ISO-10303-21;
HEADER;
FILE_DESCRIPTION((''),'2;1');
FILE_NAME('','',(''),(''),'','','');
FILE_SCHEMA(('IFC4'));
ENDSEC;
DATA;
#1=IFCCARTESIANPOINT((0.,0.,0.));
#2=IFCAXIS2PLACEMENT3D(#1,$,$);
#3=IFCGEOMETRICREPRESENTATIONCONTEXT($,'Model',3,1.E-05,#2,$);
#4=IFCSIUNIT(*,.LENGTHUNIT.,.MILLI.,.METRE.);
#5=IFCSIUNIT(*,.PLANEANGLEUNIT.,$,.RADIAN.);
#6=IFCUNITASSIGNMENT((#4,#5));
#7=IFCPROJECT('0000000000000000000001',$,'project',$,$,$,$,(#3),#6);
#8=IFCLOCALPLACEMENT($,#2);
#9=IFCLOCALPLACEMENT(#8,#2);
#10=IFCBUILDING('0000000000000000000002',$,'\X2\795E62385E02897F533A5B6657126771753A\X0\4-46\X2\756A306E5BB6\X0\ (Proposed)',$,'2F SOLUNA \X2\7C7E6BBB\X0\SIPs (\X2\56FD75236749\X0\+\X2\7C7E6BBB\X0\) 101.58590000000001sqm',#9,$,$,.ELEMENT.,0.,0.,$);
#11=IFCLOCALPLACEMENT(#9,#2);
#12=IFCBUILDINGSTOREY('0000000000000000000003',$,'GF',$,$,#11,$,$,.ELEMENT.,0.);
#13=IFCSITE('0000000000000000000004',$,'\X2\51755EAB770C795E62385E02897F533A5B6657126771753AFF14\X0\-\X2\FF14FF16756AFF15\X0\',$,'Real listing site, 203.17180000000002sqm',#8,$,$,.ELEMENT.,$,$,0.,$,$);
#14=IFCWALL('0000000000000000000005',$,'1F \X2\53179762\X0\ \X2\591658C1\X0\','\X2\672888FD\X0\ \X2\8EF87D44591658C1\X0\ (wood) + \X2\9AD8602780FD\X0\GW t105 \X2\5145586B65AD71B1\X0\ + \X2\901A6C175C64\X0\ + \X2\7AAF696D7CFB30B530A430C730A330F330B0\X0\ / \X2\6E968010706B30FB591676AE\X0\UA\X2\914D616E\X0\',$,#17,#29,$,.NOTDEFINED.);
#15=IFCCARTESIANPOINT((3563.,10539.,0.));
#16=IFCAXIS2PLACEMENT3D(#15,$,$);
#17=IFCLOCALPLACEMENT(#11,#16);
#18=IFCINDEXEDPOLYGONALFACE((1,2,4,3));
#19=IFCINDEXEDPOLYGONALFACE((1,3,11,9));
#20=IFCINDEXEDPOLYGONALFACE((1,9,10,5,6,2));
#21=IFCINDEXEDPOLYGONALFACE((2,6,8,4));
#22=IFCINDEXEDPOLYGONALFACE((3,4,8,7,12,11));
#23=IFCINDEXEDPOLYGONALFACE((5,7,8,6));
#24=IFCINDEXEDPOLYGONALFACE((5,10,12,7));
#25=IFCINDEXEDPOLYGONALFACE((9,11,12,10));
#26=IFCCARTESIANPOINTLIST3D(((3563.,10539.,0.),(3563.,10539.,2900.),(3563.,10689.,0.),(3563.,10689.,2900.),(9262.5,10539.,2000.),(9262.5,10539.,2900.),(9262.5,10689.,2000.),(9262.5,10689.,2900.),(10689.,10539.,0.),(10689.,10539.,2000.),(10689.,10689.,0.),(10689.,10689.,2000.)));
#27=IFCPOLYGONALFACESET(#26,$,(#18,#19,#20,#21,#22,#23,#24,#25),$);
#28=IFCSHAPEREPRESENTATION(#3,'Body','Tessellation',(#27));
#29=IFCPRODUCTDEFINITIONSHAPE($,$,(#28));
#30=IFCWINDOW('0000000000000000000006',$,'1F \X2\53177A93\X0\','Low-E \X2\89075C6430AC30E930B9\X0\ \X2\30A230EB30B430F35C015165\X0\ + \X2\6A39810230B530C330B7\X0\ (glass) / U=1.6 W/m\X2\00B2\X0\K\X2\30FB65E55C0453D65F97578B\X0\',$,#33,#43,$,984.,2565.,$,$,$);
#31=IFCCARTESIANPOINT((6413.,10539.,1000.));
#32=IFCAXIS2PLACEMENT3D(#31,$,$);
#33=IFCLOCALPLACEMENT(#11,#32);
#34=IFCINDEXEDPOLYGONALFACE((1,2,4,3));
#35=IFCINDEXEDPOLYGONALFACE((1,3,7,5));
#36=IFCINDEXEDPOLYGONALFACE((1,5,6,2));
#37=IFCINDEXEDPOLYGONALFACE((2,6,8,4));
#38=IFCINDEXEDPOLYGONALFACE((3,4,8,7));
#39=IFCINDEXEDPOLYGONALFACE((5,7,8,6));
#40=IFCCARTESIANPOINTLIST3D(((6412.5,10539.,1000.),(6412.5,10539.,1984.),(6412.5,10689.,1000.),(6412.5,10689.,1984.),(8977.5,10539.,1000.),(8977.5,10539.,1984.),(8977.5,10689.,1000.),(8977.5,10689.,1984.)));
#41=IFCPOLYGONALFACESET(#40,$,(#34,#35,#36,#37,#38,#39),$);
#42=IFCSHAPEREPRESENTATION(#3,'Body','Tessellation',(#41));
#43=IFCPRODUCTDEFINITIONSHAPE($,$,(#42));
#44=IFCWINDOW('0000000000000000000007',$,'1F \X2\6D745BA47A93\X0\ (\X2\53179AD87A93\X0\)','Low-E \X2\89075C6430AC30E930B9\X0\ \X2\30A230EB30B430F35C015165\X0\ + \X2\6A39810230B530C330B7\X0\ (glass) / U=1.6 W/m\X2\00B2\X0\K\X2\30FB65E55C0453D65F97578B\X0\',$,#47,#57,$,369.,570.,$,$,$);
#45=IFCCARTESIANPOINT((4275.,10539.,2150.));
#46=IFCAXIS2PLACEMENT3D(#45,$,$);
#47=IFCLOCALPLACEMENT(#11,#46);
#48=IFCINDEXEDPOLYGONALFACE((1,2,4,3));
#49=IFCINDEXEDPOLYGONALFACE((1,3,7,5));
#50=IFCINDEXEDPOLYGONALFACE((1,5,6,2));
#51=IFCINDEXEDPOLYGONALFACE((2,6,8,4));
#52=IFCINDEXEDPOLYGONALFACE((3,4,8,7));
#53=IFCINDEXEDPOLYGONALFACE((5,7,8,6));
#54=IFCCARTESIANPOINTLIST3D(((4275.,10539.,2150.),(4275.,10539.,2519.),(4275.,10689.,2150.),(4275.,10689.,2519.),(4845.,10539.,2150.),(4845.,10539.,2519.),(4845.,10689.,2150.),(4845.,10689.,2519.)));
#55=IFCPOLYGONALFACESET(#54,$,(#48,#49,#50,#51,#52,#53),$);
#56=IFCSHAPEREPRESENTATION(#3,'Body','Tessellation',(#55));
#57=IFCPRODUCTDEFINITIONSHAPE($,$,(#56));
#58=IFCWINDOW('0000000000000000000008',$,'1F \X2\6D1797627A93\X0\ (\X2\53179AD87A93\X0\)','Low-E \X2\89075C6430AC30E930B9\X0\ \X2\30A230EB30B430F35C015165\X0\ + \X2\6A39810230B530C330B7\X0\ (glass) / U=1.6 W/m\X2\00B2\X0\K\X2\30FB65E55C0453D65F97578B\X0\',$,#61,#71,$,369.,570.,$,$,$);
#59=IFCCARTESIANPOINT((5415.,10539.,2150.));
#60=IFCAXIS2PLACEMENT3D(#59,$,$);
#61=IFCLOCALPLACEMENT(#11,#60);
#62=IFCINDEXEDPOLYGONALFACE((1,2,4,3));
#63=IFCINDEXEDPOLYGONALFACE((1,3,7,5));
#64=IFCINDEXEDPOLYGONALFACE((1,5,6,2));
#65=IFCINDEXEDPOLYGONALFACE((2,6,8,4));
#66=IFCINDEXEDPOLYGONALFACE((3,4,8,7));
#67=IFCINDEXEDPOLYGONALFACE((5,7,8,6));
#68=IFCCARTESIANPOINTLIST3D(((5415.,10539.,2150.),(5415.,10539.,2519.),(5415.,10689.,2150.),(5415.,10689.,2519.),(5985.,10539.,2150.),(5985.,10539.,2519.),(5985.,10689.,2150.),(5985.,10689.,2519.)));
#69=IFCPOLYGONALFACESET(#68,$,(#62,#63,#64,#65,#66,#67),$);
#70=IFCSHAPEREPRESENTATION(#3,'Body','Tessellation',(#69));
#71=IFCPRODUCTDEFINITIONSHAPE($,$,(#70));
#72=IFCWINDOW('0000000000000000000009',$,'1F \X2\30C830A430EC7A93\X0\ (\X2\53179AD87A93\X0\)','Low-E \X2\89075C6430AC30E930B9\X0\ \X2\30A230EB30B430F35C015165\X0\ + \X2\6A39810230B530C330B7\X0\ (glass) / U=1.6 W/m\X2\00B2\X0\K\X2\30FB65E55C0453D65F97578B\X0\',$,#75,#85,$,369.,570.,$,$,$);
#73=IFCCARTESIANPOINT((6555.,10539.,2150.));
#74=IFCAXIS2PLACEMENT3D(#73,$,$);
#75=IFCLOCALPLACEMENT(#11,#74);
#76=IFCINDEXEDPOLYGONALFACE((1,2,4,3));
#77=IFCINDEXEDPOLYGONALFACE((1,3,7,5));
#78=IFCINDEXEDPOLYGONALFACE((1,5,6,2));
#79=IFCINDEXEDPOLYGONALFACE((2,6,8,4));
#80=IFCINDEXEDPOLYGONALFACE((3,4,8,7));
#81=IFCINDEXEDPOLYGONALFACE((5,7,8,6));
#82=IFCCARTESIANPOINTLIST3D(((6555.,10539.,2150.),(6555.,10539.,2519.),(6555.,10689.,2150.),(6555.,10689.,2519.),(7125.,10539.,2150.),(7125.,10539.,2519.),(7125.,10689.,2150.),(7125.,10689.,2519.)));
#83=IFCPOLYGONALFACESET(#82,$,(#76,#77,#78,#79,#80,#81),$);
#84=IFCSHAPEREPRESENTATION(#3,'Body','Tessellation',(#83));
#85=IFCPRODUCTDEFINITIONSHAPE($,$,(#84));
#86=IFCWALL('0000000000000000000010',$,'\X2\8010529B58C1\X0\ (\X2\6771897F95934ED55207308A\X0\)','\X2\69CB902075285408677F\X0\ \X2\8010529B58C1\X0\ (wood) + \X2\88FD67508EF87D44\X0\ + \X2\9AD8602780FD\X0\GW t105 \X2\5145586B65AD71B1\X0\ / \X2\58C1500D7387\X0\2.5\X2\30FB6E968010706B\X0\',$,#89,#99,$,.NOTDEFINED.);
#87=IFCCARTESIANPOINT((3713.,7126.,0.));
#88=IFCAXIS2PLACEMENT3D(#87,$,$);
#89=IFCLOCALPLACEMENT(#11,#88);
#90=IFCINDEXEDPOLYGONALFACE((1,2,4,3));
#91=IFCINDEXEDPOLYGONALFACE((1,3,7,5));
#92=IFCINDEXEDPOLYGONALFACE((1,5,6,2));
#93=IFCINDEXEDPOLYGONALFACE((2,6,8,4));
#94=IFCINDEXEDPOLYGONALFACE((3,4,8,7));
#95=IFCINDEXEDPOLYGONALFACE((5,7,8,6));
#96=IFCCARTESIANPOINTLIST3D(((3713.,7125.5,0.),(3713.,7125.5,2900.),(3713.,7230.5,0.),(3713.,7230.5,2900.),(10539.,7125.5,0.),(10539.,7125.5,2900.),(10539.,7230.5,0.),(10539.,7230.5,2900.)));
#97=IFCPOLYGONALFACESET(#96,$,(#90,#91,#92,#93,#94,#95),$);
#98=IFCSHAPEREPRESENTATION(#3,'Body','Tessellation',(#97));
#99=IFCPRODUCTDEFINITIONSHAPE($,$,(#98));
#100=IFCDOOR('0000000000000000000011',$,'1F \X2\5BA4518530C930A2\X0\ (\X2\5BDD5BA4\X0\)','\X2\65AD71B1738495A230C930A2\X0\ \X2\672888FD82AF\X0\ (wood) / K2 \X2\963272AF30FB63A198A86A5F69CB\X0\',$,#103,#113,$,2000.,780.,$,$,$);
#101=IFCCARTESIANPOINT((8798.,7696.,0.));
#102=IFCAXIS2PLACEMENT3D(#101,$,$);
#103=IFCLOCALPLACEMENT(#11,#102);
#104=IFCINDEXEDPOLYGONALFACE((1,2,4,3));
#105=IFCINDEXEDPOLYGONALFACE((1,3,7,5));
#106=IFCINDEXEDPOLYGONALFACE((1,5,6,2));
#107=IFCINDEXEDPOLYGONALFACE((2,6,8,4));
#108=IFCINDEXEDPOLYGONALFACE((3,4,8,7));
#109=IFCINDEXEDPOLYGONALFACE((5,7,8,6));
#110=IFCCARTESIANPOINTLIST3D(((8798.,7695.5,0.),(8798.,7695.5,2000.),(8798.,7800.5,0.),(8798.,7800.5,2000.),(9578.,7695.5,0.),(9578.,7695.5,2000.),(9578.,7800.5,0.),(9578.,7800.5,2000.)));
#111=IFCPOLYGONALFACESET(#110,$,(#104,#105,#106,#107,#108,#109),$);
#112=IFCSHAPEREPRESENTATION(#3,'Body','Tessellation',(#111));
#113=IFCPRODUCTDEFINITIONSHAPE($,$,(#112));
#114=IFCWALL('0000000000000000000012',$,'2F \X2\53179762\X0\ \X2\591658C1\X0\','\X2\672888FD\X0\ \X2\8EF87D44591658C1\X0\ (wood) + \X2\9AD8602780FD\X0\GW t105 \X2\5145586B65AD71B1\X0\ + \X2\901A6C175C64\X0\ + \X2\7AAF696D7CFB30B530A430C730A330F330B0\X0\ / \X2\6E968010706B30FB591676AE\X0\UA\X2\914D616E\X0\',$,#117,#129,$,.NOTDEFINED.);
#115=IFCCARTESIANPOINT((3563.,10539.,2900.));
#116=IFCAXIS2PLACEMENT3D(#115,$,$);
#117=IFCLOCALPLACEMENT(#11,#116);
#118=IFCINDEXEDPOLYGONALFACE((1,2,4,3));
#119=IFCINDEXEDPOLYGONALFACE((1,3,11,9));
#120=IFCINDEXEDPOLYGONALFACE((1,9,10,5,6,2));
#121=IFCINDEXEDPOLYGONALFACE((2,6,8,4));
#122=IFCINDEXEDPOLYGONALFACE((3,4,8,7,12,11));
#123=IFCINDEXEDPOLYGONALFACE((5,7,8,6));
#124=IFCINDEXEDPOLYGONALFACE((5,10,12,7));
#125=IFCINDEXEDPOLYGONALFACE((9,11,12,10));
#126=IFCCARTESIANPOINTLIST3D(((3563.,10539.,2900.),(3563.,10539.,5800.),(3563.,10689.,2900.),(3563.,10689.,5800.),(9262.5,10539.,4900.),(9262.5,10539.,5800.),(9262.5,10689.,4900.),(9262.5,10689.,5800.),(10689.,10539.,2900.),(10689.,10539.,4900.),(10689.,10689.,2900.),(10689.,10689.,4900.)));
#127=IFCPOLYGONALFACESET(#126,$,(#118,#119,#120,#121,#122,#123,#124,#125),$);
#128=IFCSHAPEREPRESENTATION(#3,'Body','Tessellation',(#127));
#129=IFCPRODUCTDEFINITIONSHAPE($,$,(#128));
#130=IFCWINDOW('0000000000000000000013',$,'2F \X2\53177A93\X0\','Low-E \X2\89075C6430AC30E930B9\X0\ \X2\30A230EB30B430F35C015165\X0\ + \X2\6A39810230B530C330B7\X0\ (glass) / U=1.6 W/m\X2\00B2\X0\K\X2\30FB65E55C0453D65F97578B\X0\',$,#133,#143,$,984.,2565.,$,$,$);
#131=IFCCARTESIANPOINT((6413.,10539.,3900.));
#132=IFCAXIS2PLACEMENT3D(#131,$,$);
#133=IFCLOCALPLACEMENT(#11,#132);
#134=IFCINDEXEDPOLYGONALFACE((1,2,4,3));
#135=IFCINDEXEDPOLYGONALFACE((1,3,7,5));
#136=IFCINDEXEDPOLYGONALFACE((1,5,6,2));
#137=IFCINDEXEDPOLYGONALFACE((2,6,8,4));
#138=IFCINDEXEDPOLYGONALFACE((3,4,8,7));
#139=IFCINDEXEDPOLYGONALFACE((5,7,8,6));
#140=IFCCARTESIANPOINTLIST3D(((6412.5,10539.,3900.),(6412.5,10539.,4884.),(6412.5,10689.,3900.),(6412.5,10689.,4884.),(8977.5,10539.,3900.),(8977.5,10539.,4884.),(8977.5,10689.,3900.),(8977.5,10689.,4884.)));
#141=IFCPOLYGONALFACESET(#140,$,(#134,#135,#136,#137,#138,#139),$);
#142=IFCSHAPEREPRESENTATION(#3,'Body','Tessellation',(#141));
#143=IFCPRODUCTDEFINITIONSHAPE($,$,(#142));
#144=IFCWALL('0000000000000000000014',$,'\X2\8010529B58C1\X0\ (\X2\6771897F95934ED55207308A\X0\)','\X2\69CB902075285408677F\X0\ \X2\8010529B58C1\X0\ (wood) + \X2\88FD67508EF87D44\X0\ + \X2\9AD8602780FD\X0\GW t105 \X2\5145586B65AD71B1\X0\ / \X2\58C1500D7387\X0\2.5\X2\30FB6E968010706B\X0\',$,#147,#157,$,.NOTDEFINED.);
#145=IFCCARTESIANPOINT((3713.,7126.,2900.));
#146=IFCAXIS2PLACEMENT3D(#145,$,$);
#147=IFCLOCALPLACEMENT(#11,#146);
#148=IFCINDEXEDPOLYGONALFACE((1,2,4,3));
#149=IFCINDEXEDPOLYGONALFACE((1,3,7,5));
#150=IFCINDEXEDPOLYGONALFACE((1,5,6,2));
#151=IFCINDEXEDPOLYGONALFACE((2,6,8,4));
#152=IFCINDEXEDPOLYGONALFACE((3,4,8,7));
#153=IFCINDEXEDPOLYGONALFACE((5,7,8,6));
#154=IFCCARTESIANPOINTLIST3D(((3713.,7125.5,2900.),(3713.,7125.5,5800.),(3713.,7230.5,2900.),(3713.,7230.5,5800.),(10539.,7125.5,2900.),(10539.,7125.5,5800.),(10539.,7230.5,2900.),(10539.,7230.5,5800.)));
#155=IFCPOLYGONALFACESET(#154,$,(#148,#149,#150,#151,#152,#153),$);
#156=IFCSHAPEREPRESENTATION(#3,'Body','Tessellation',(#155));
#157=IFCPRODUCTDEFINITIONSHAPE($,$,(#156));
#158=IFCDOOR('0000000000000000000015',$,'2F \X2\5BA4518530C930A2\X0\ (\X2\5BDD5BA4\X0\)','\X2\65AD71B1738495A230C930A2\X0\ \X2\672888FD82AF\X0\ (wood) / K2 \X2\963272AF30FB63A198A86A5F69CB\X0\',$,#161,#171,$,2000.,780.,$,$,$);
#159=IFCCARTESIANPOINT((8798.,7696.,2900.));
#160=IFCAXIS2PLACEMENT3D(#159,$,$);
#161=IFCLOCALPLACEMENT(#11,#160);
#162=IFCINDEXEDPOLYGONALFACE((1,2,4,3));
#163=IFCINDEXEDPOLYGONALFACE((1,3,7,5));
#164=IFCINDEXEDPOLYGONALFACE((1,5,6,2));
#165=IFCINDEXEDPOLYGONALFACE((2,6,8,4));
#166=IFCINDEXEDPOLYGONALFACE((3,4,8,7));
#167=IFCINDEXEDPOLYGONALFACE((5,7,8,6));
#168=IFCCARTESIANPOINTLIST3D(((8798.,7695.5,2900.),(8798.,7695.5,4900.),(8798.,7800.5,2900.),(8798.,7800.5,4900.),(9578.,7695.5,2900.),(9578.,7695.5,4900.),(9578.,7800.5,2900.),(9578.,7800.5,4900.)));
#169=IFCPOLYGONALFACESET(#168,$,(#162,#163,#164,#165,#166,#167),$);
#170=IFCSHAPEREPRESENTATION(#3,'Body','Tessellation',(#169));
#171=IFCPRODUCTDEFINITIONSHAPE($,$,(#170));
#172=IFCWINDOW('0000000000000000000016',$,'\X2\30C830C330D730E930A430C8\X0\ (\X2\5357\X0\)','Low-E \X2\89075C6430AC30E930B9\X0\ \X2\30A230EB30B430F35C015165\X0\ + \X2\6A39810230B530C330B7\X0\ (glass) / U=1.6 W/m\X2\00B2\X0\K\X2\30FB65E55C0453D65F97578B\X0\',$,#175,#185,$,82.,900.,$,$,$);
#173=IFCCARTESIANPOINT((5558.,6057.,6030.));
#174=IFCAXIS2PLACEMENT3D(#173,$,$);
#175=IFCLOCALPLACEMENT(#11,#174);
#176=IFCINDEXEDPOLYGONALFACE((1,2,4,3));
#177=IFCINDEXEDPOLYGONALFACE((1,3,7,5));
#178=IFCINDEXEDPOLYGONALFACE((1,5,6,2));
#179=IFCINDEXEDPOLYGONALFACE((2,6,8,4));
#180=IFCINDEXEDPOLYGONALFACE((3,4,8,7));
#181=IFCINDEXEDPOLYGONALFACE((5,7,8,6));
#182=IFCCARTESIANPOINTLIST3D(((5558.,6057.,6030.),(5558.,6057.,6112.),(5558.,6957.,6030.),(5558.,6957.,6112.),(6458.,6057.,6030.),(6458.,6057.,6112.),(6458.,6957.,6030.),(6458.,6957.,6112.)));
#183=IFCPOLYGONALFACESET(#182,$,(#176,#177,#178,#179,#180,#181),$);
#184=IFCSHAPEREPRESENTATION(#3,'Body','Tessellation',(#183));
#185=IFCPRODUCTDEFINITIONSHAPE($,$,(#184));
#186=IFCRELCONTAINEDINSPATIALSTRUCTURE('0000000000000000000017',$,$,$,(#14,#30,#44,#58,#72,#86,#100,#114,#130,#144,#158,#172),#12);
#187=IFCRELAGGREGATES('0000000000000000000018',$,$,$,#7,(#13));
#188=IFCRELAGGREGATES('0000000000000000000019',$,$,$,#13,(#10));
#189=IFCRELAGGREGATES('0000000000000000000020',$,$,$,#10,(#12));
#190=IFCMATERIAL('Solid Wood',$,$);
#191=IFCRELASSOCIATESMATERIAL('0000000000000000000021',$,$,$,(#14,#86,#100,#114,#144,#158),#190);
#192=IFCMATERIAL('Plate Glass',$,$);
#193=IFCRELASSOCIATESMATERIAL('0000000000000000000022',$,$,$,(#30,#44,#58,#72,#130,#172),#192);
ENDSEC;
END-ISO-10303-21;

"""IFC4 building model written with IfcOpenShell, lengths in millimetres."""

from ifc_helpers import new_model, si_unit, frame, frame_2d, origin, place, context, project, spatial, rectangle, extrude, material, element, fill, save


model = new_model("IFC4")

# Units and contexts
model_context = context("Model", 3, precision=1e-05, world=origin())
ifc_project = project(units=[si_unit("LENGTHUNIT", "METRE", prefix="MILLI"), si_unit("PLANEANGLEUNIT", "RADIAN")], contexts=[model_context])

# Site, building, storey
site_placement = place(None, origin())
site = spatial("IfcSite", under=ifc_project, at=site_placement, Name="兵庫県神戸市西区学園東町４-４６番５", ObjectType="Real listing site, 203.17180000000002sqm", CompositionType="ELEMENT", RefElevation=0.0)
building_placement = place(site_placement, origin())
building = spatial("IfcBuilding", under=site, at=building_placement, Name="神戸市西区学園東町4-46番の家 (Proposed)", ObjectType="2F SOLUNA 籾殻SIPs (国産杉+籾殻) 101.58590000000001sqm", CompositionType="ELEMENT", ElevationOfRefHeight=0.0, ElevationOfTerrain=0.0)
storey_placement = place(building_placement, origin())
storey = spatial("IfcBuildingStorey", under=building, at=storey_placement, Name="GF", CompositionType="ELEMENT", Elevation=0.0)

# Wall, openings, windows
ifc_material_1 = material(Name="Solid Wood")
wall_1_placement = place(storey_placement, frame((3563.0, 10539.0, 0.0)))
wall_1 = element("IfcWall", 1, at=wall_1_placement, inside=storey, material=ifc_material_1, Name="1F 北面 外壁", Description="木製 軸組外壁 (wood) + 高性能GW t105 充填断熱 + 通気層 + 窯業系サイディング / 準耐火・外皮UA配慮", PredefinedType="NOTDEFINED", context=model_context, shape_type="SweptSolid", body=[
    extrude(rectangle(XDim=7126.0, YDim=150.0, at=frame_2d((3563.0, 75.0))), frame((3563.0, 10539.0, 0.0)), (0.0, 0.0, 1.0), 2900.0),
])
opening_1_placement = place(storey_placement, frame((6413.0, 10539.0, 1000.0)))
opening_1 = element("IfcOpeningElement", 2, at=opening_1_placement, cuts=wall_1, PredefinedType="NOTDEFINED", context=model_context, shape_type="SweptSolid", body=[
    extrude(rectangle(XDim=2565.0, YDim=150.0, at=frame_2d((1282.0, 75.0))), frame((6413.0, 10539.0, 1000.0)), (0.0, 0.0, 1.0), 984.0),
])
opening_2_placement = place(storey_placement, frame((4275.0, 10539.0, 2150.0)))
opening_2 = element("IfcOpeningElement", 3, at=opening_2_placement, cuts=wall_1, PredefinedType="NOTDEFINED", context=model_context, shape_type="SweptSolid", body=[
    extrude(rectangle(XDim=570.0, YDim=150.0, at=frame_2d((285.0, 75.0))), frame((4275.0, 10539.0, 2150.0)), (0.0, 0.0, 1.0), 369.0),
])
opening_3_placement = place(storey_placement, frame((5415.0, 10539.0, 2150.0)))
opening_3 = element("IfcOpeningElement", 4, at=opening_3_placement, cuts=wall_1, PredefinedType="NOTDEFINED", context=model_context, shape_type="SweptSolid", body=[
    extrude(rectangle(XDim=570.0, YDim=150.0, at=frame_2d((285.0, 75.0))), frame((5415.0, 10539.0, 2150.0)), (0.0, 0.0, 1.0), 369.0),
])
opening_4_placement = place(storey_placement, frame((6555.0, 10539.0, 2150.0)))
opening_4 = element("IfcOpeningElement", 5, at=opening_4_placement, cuts=wall_1, PredefinedType="NOTDEFINED", context=model_context, shape_type="SweptSolid", body=[
    extrude(rectangle(XDim=570.0, YDim=150.0, at=frame_2d((285.0, 75.0))), frame((6555.0, 10539.0, 2150.0)), (0.0, 0.0, 1.0), 369.0),
])
ifc_material_2 = material(Name="Plate Glass")
window_1_placement = place(storey_placement, frame((6413.0, 10539.0, 1000.0)))
window_1 = element("IfcWindow", 6, at=window_1_placement, inside=storey, material=ifc_material_2, Name="1F 北窓", Description="Low-E 複層ガラス アルゴン封入 + 樹脂サッシ (glass) / U=1.6 W/m²K・日射取得型", OverallHeight=984.0, OverallWidth=2565.0, context=model_context, shape_type="SweptSolid", body=[
    extrude(rectangle(XDim=2565.0, YDim=150.0, at=frame_2d((1282.0, 75.0))), frame((6413.0, 10539.0, 1000.0)), (0.0, 0.0, 1.0), 984.0),
])
fill(opening_1, window_1)
window_2_placement = place(storey_placement, frame((4275.0, 10539.0, 2150.0)))
window_2 = element("IfcWindow", 7, at=window_2_placement, inside=storey, material=ifc_material_2, Name="1F 浴室窓 (北高窓)", Description="Low-E 複層ガラス アルゴン封入 + 樹脂サッシ (glass) / U=1.6 W/m²K・日射取得型", OverallHeight=369.0, OverallWidth=570.0, context=model_context, shape_type="SweptSolid", body=[
    extrude(rectangle(XDim=570.0, YDim=150.0, at=frame_2d((285.0, 75.0))), frame((4275.0, 10539.0, 2150.0)), (0.0, 0.0, 1.0), 369.0),
])
fill(opening_2, window_2)
window_3_placement = place(storey_placement, frame((5415.0, 10539.0, 2150.0)))
window_3 = element("IfcWindow", 8, at=window_3_placement, inside=storey, material=ifc_material_2, Name="1F 洗面窓 (北高窓)", Description="Low-E 複層ガラス アルゴン封入 + 樹脂サッシ (glass) / U=1.6 W/m²K・日射取得型", OverallHeight=369.0, OverallWidth=570.0, context=model_context, shape_type="SweptSolid", body=[
    extrude(rectangle(XDim=570.0, YDim=150.0, at=frame_2d((285.0, 75.0))), frame((5415.0, 10539.0, 2150.0)), (0.0, 0.0, 1.0), 369.0),
])
fill(opening_3, window_3)
window_4_placement = place(storey_placement, frame((6555.0, 10539.0, 2150.0)))
window_4 = element("IfcWindow", 9, at=window_4_placement, inside=storey, material=ifc_material_2, Name="1F トイレ窓 (北高窓)", Description="Low-E 複層ガラス アルゴン封入 + 樹脂サッシ (glass) / U=1.6 W/m²K・日射取得型", OverallHeight=369.0, OverallWidth=570.0, context=model_context, shape_type="SweptSolid", body=[
    extrude(rectangle(XDim=570.0, YDim=150.0, at=frame_2d((285.0, 75.0))), frame((6555.0, 10539.0, 2150.0)), (0.0, 0.0, 1.0), 369.0),
])
fill(opening_4, window_4)

# Wall
wall_2_placement = place(storey_placement, frame((3713.0, 7126.0, 0.0)))
element("IfcWall", 10, at=wall_2_placement, inside=storey, material=ifc_material_1, Name="耐力壁 (東西間仕切り)", Description="構造用合板 耐力壁 (wood) + 製材軸組 + 高性能GW t105 充填断熱 / 壁倍率2.5・準耐火", PredefinedType="NOTDEFINED", context=model_context, shape_type="SweptSolid", body=[
    extrude(rectangle(XDim=6826.0, YDim=105.0, at=frame_2d((3413.0, 52.0))), frame((3713.0, 7126.0, 0.0)), (0.0, 0.0, 1.0), 2900.0),
])

# Door
door_1_placement = place(storey_placement, frame((8798.0, 7696.0, 0.0)))
element("IfcDoor", 11, at=door_1_placement, inside=storey, material=ifc_material_1, Name="1F 室内ドア (寝室)", Description="断熱玄関ドア 木製芯 (wood) / K2 防犯・採風機構", OverallHeight=2000.0, OverallWidth=780.0, context=model_context, shape_type="SweptSolid", body=[
    extrude(rectangle(XDim=780.0, YDim=105.0, at=frame_2d((390.0, 52.0))), frame((8798.0, 7696.0, 0.0)), (0.0, 0.0, 1.0), 2000.0),
])

# Wall, opening, window
wall_3_placement = place(storey_placement, frame((3563.0, 10539.0, 2900.0)))
wall_3 = element("IfcWall", 12, at=wall_3_placement, inside=storey, material=ifc_material_1, Name="2F 北面 外壁", Description="木製 軸組外壁 (wood) + 高性能GW t105 充填断熱 + 通気層 + 窯業系サイディング / 準耐火・外皮UA配慮", PredefinedType="NOTDEFINED", context=model_context, shape_type="SweptSolid", body=[
    extrude(rectangle(XDim=7126.0, YDim=150.0, at=frame_2d((3563.0, 75.0))), frame((3563.0, 10539.0, 2900.0)), (0.0, 0.0, 1.0), 2900.0),
])
opening_5_placement = place(storey_placement, frame((6413.0, 10539.0, 3900.0)))
opening_5 = element("IfcOpeningElement", 13, at=opening_5_placement, cuts=wall_3, PredefinedType="NOTDEFINED", context=model_context, shape_type="SweptSolid", body=[
    extrude(rectangle(XDim=2565.0, YDim=150.0, at=frame_2d((1282.0, 75.0))), frame((6413.0, 10539.0, 3900.0)), (0.0, 0.0, 1.0), 984.0),
])
window_5_placement = place(storey_placement, frame((6413.0, 10539.0, 3900.0)))
window_5 = element("IfcWindow", 14, at=window_5_placement, inside=storey, material=ifc_material_2, Name="2F 北窓", Description="Low-E 複層ガラス アルゴン封入 + 樹脂サッシ (glass) / U=1.6 W/m²K・日射取得型", OverallHeight=984.0, OverallWidth=2565.0, context=model_context, shape_type="SweptSolid", body=[
    extrude(rectangle(XDim=2565.0, YDim=150.0, at=frame_2d((1282.0, 75.0))), frame((6413.0, 10539.0, 3900.0)), (0.0, 0.0, 1.0), 984.0),
])
fill(opening_5, window_5)

# Wall
wall_4_placement = place(storey_placement, frame((3713.0, 7126.0, 2900.0)))
element("IfcWall", 15, at=wall_4_placement, inside=storey, material=ifc_material_1, Name="耐力壁 (東西間仕切り)", Description="構造用合板 耐力壁 (wood) + 製材軸組 + 高性能GW t105 充填断熱 / 壁倍率2.5・準耐火", PredefinedType="NOTDEFINED", context=model_context, shape_type="SweptSolid", body=[
    extrude(rectangle(XDim=6826.0, YDim=105.0, at=frame_2d((3413.0, 52.0))), frame((3713.0, 7126.0, 2900.0)), (0.0, 0.0, 1.0), 2900.0),
])

# Door
door_2_placement = place(storey_placement, frame((8798.0, 7696.0, 2900.0)))
element("IfcDoor", 16, at=door_2_placement, inside=storey, material=ifc_material_1, Name="2F 室内ドア (寝室)", Description="断熱玄関ドア 木製芯 (wood) / K2 防犯・採風機構", OverallHeight=2000.0, OverallWidth=780.0, context=model_context, shape_type="SweptSolid", body=[
    extrude(rectangle(XDim=780.0, YDim=105.0, at=frame_2d((390.0, 52.0))), frame((8798.0, 7696.0, 2900.0)), (0.0, 0.0, 1.0), 2000.0),
])

# Window
window_6_placement = place(storey_placement, frame((5558.0, 6057.0, 6030.0)))
element("IfcWindow", 17, at=window_6_placement, inside=storey, material=ifc_material_2, Name="トップライト (南)", Description="Low-E 複層ガラス アルゴン封入 + 樹脂サッシ (glass) / U=1.6 W/m²K・日射取得型", OverallHeight=82.0, OverallWidth=900.0, context=model_context, shape_type="SweptSolid", body=[
    extrude(rectangle(XDim=900.0, YDim=900.0, at=frame_2d((450.0, 450.0))), frame((5558.0, 6057.0, 6030.0)), (0.0, 0.0, 1.0), 82.0),
])

save(model, "model.ifc")
